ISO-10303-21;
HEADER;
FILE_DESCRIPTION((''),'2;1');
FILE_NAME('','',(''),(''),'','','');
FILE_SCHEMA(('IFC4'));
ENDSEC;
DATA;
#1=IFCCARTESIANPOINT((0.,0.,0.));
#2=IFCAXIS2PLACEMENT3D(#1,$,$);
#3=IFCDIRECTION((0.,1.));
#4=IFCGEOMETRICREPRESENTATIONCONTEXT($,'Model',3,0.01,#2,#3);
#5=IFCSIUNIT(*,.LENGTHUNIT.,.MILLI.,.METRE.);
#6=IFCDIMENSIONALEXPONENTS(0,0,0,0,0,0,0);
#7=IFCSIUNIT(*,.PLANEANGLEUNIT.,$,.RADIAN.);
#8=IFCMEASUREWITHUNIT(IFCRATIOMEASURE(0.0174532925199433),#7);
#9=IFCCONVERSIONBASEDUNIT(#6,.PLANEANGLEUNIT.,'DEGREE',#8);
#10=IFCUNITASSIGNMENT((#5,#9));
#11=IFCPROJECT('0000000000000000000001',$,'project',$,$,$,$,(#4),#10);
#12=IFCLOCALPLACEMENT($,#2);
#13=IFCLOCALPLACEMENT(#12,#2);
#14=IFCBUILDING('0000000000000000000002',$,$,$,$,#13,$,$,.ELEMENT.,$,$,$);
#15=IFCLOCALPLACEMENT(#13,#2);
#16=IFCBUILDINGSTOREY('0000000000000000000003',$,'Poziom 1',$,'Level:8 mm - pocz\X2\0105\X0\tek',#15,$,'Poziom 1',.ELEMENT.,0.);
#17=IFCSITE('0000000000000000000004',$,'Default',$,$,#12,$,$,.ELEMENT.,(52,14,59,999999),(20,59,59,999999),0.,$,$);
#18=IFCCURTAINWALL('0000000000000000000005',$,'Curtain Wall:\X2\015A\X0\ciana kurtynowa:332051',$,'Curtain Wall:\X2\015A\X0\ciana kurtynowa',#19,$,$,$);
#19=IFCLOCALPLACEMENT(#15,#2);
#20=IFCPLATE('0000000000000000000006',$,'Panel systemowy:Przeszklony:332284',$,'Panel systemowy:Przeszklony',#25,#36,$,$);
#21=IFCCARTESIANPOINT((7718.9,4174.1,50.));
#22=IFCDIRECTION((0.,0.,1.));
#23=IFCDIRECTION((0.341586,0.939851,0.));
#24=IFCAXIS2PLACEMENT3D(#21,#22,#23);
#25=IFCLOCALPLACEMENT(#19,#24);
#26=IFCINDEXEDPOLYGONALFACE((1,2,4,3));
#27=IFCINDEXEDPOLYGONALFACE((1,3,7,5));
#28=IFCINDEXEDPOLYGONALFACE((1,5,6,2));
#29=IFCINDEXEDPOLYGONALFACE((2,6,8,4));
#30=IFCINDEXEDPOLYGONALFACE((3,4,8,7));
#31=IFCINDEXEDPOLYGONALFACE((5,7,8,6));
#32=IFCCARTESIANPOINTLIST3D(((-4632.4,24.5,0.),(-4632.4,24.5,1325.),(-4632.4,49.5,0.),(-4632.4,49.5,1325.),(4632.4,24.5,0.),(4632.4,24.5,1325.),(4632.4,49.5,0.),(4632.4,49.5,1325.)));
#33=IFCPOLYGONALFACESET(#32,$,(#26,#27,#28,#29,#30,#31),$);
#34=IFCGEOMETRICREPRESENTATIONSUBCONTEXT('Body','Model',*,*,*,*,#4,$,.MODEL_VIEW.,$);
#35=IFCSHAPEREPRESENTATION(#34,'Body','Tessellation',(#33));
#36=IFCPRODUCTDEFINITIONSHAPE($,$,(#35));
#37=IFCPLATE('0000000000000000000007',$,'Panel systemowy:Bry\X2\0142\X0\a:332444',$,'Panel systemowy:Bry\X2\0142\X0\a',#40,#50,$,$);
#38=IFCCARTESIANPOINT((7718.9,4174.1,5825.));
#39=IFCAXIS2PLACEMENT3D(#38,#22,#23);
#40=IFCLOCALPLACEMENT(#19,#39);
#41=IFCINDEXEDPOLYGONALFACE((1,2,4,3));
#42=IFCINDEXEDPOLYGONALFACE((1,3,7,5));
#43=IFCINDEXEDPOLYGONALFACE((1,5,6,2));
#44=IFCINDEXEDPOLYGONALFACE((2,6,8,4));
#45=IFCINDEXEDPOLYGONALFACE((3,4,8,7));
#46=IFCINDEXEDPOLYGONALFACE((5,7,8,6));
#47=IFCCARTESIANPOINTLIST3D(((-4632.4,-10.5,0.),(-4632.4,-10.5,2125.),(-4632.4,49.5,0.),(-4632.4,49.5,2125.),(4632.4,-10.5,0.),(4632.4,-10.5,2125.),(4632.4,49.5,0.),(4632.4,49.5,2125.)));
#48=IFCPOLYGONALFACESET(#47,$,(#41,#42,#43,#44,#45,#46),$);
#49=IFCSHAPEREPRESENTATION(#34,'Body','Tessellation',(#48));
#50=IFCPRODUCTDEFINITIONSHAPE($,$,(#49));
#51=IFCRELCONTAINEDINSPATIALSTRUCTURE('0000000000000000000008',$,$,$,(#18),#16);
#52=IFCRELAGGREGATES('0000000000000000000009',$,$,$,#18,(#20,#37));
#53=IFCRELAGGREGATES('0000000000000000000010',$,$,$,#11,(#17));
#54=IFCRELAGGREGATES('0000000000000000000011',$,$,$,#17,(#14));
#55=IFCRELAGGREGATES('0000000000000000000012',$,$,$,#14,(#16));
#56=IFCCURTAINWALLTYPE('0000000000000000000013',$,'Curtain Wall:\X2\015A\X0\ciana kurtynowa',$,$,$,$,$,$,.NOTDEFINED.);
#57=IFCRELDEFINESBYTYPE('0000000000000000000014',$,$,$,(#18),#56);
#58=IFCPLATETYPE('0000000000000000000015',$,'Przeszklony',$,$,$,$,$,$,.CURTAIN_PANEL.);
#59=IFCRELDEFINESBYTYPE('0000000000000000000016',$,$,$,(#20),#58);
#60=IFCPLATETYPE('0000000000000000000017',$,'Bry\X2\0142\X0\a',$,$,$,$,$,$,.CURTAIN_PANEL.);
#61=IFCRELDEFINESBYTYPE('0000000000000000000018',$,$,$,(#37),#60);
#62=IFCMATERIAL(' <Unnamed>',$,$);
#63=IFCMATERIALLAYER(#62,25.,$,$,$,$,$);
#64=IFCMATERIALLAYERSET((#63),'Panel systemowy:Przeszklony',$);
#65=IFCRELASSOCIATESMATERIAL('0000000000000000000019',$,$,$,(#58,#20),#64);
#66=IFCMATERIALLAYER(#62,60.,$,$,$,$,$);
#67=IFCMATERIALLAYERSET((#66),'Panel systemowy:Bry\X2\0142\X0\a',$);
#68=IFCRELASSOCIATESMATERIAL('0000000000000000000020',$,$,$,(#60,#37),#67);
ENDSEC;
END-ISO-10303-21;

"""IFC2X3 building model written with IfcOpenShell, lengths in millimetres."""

from ifc_helpers import new_model, entity, si_unit, converted_unit, direction, frame, frame_2d, origin, origin_2d_with_axis, place, context, subcontext, project, spatial, rectangle, extrude, source, transform, mapped, material, layer, layer_set, layer_usage, type_object, type_shapes, element, aggregate, save


model = new_model("IFC2X3")

# Units and contexts
model_context = context("Model", 3, precision=0.01, world=origin(), true_north=direction((0.0, 1.0)))
body_context = subcontext(model_context, "Body", "Model", "MODEL_VIEW")
ifc_project = project(units=[si_unit("LENGTHUNIT", "METRE", prefix="MILLI"), converted_unit("PLANEANGLEUNIT", "DEGREE", entity("IfcRatioMeasure", 0.0174532925199433), si_unit("PLANEANGLEUNIT", "RADIAN"), dimensions=[0, 0, 0, 0, 0, 0, 0])], contexts=[model_context])

# Site, building, storey
site_placement = place(None, origin())
site = spatial("IfcSite", under=ifc_project, at=site_placement, Name="Default", CompositionType="ELEMENT", RefLatitude=(52, 14, 59, 999999), RefLongitude=(20, 59, 59, 999999), RefElevation=0.0)
building_placement = place(site_placement, origin())
building = spatial("IfcBuilding", under=site, at=building_placement, CompositionType="ELEMENT")
storey_placement = place(building_placement, origin())
storey = spatial("IfcBuildingStorey", under=building, at=storey_placement, Name="Poziom 1", ObjectType="Level:8 mm - początek", LongName="Poziom 1", CompositionType="ELEMENT", Elevation=0.0)

# Curtain wall, plates
curtain_wall_type = type_object("IfcCurtainWallType", Name="Curtain Wall:Ściana kurtynowa", PredefinedType="NOTDEFINED")
curtain_wall_placement = place(storey_placement, origin())
curtain_wall = element("IfcCurtainWall", 1, at=curtain_wall_placement, inside=storey, type_object=curtain_wall_type, Name="Curtain Wall:Ściana kurtynowa:332051", ObjectType="Curtain Wall:Ściana kurtynowa")
ifc_material_1 = material(Name=" <Unnamed>")
ifc_layer_1 = layer(ifc_material_1, 25.0)
ifc_layer_set_1 = layer_set([ifc_layer_1], Name="Panel systemowy:Przeszklony")
ifc_layer_usage_1 = layer_usage(ifc_layer_set_1, "AXIS3", "POSITIVE", 0.1)
plate_type_1 = type_object("IfcPlateType", Name="Przeszklony", PredefinedType="CURTAIN_PANEL", material=ifc_layer_set_1)
shared_shape_1 = source(origin(), body_context, "Body", "SweptSolid", [
    extrude(rectangle(XDim=25.0, YDim=9264.9, at=frame_2d((0.0, 0.0), x_axis=(1.0, 0.0))), frame((0.0, 37.0, 0.0), z_axis=(0.0, 0.0, 1.0), x_axis=(0.0, 1.0, 0.0)), (0.0, 0.0, 1.0), 1325.0),
])
type_shapes(plate_type_1, [shared_shape_1])
plate_1_placement = place(curtain_wall_placement, frame((7718.9, 4174.1, 50.0), z_axis=(0.0, 0.0, 1.0), x_axis=(0.341586, 0.939851, 0.0)))
plate_1 = element("IfcPlate", 2, at=plate_1_placement, type_object=plate_type_1, material=ifc_layer_usage_1, Name="Panel systemowy:Przeszklony:332284", ObjectType="Panel systemowy:Przeszklony", context=body_context, shape_type="MappedRepresentation", body=[
    mapped(shared_shape_1, transform((0.0, 0.0, 0.0), scale=1.0)),
])
ifc_layer_2 = layer(ifc_material_1, 60.0)
ifc_layer_set_2 = layer_set([ifc_layer_2], Name="Panel systemowy:Bryła")
ifc_layer_usage_2 = layer_usage(ifc_layer_set_2, "AXIS3", "POSITIVE", 0.1)
plate_type_2 = type_object("IfcPlateType", Name="Bryła", PredefinedType="CURTAIN_PANEL", material=ifc_layer_set_2)
shared_shape_2 = source(origin(), body_context, "Body", "SweptSolid", [
    extrude(rectangle(XDim=60.0, YDim=9264.9, at=origin_2d_with_axis()), frame((0.0, 19.5, 0.0), z_axis=(0.0, 0.0, 1.0), x_axis=(0.0, 1.0, 0.0)), (0.0, 0.0, 1.0), 2125.0),
])
type_shapes(plate_type_2, [shared_shape_2])
plate_2_placement = place(curtain_wall_placement, frame((7718.9, 4174.1, 5825.0), z_axis=(0.0, 0.0, 1.0), x_axis=(0.341586, 0.939851, 0.0)))
plate_2 = element("IfcPlate", 3, at=plate_2_placement, type_object=plate_type_2, material=ifc_layer_usage_2, Name="Panel systemowy:Bryła:332444", ObjectType="Panel systemowy:Bryła", context=body_context, shape_type="MappedRepresentation", body=[
    mapped(shared_shape_2, transform((0.0, 0.0, 0.0), scale=1.0)),
])
aggregate(curtain_wall, [plate_1, plate_2])

save(model, "model.ifc")
